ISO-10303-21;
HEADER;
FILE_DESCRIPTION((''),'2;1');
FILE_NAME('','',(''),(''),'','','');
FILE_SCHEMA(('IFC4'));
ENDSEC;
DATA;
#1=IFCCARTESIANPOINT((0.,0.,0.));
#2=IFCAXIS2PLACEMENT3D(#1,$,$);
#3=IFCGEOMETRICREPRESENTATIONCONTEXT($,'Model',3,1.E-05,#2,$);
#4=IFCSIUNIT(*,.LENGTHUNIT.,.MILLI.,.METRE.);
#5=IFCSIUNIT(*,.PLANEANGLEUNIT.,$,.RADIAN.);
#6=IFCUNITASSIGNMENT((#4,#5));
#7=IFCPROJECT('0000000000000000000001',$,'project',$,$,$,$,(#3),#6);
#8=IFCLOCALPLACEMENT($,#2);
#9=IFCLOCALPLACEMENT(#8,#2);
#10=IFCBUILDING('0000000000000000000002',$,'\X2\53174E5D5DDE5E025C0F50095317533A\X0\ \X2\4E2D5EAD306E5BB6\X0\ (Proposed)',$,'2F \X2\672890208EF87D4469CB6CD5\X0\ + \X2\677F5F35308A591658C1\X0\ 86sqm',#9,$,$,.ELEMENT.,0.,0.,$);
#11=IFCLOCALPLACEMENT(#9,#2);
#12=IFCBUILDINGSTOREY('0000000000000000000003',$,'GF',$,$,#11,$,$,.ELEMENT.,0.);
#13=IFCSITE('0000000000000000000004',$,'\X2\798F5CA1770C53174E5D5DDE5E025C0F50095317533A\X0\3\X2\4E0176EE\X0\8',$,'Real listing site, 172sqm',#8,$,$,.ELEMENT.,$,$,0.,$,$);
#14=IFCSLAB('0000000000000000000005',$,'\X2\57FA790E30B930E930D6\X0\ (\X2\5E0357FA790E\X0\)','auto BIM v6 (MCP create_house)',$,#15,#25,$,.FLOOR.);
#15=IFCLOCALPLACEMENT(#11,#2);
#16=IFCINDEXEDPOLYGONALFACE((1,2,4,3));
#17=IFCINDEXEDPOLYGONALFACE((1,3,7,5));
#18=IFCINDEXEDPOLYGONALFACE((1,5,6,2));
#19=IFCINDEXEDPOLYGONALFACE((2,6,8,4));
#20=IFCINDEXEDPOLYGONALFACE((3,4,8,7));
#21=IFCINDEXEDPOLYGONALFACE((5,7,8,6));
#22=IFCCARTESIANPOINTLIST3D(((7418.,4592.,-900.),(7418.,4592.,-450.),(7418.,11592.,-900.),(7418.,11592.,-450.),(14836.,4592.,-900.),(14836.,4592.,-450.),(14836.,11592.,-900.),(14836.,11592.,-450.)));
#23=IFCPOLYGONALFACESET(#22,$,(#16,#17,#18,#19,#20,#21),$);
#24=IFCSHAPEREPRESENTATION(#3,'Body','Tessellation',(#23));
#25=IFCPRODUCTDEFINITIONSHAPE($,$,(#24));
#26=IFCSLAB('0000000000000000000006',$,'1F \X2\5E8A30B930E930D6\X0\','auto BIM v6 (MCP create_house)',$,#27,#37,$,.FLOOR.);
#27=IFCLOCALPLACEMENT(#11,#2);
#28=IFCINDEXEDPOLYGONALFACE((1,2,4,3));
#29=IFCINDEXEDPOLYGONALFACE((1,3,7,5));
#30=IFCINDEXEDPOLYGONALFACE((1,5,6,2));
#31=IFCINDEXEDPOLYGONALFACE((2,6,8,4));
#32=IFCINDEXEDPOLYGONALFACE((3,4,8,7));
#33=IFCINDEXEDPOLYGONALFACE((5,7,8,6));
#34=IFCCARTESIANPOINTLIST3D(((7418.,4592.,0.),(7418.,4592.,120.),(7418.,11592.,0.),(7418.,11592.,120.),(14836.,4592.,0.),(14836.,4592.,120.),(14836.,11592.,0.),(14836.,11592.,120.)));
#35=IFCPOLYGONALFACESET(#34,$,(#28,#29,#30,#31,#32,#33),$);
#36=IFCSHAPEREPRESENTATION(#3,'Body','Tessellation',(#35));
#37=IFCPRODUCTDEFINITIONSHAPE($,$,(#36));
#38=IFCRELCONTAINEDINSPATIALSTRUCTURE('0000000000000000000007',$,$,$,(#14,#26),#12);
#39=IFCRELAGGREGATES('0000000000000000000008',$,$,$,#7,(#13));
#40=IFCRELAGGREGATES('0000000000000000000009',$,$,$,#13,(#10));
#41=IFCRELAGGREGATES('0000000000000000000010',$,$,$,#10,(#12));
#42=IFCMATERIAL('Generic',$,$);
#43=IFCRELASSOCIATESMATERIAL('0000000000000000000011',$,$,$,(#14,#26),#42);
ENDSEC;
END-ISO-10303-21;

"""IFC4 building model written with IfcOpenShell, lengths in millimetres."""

from ifc_helpers import new_model, si_unit, frame, frame_2d, origin, place, context, project, spatial, rectangle, extrude, material, element, save


model = new_model("IFC4")

# Units and contexts
model_context = context("Model", 3, precision=1e-05, world=origin())
ifc_project = project(units=[si_unit("LENGTHUNIT", "METRE", prefix="MILLI"), si_unit("PLANEANGLEUNIT", "RADIAN")], contexts=[model_context])

# Site, building, storey
site_placement = place(None, origin())
site = spatial("IfcSite", under=ifc_project, at=site_placement, Name="福岡県北九州市小倉北区3丁目8", ObjectType="Real listing site, 172sqm", CompositionType="ELEMENT", RefElevation=0.0)
building_placement = place(site_placement, origin())
building = spatial("IfcBuilding", under=site, at=building_placement, Name="北九州市小倉北区 中庭の家 (Proposed)", ObjectType="2F 木造軸組構法 + 板張り外壁 86sqm", CompositionType="ELEMENT", ElevationOfRefHeight=0.0, ElevationOfTerrain=0.0)
storey_placement = place(building_placement, origin())
storey = spatial("IfcBuildingStorey", under=building, at=storey_placement, Name="GF", CompositionType="ELEMENT", Elevation=0.0)

# Slabs
ifc_material = material(Name="Generic")
slab_1_placement = place(storey_placement, frame((3709.0, 2296.0, -450.0)))
element("IfcSlab", 1, at=slab_1_placement, inside=storey, material=ifc_material, Name="基礎スラブ (布基礎)", Description="auto BIM v6 (MCP create_house)", PredefinedType="FLOOR", context=model_context, shape_type="SweptSolid", body=[
    extrude(rectangle(XDim=7418.0, YDim=7000.0, at=frame_2d((3709.0, 3500.0))), frame((3709.0, 2296.0, -450.0)), (0.0, 0.0, 1.0), 450.0),
])
slab_2_placement = place(storey_placement, frame((3709.0, 2296.0, 0.0)))
element("IfcSlab", 2, at=slab_2_placement, inside=storey, material=ifc_material, Name="1F 床スラブ", Description="auto BIM v6 (MCP create_house)", PredefinedType="FLOOR", context=model_context, shape_type="SweptSolid", body=[
    extrude(rectangle(XDim=7418.0, YDim=7000.0, at=frame_2d((3709.0, 3500.0))), frame((3709.0, 2296.0, 0.0)), (0.0, 0.0, 1.0), 120.0),
])

save(model, "model.ifc")
